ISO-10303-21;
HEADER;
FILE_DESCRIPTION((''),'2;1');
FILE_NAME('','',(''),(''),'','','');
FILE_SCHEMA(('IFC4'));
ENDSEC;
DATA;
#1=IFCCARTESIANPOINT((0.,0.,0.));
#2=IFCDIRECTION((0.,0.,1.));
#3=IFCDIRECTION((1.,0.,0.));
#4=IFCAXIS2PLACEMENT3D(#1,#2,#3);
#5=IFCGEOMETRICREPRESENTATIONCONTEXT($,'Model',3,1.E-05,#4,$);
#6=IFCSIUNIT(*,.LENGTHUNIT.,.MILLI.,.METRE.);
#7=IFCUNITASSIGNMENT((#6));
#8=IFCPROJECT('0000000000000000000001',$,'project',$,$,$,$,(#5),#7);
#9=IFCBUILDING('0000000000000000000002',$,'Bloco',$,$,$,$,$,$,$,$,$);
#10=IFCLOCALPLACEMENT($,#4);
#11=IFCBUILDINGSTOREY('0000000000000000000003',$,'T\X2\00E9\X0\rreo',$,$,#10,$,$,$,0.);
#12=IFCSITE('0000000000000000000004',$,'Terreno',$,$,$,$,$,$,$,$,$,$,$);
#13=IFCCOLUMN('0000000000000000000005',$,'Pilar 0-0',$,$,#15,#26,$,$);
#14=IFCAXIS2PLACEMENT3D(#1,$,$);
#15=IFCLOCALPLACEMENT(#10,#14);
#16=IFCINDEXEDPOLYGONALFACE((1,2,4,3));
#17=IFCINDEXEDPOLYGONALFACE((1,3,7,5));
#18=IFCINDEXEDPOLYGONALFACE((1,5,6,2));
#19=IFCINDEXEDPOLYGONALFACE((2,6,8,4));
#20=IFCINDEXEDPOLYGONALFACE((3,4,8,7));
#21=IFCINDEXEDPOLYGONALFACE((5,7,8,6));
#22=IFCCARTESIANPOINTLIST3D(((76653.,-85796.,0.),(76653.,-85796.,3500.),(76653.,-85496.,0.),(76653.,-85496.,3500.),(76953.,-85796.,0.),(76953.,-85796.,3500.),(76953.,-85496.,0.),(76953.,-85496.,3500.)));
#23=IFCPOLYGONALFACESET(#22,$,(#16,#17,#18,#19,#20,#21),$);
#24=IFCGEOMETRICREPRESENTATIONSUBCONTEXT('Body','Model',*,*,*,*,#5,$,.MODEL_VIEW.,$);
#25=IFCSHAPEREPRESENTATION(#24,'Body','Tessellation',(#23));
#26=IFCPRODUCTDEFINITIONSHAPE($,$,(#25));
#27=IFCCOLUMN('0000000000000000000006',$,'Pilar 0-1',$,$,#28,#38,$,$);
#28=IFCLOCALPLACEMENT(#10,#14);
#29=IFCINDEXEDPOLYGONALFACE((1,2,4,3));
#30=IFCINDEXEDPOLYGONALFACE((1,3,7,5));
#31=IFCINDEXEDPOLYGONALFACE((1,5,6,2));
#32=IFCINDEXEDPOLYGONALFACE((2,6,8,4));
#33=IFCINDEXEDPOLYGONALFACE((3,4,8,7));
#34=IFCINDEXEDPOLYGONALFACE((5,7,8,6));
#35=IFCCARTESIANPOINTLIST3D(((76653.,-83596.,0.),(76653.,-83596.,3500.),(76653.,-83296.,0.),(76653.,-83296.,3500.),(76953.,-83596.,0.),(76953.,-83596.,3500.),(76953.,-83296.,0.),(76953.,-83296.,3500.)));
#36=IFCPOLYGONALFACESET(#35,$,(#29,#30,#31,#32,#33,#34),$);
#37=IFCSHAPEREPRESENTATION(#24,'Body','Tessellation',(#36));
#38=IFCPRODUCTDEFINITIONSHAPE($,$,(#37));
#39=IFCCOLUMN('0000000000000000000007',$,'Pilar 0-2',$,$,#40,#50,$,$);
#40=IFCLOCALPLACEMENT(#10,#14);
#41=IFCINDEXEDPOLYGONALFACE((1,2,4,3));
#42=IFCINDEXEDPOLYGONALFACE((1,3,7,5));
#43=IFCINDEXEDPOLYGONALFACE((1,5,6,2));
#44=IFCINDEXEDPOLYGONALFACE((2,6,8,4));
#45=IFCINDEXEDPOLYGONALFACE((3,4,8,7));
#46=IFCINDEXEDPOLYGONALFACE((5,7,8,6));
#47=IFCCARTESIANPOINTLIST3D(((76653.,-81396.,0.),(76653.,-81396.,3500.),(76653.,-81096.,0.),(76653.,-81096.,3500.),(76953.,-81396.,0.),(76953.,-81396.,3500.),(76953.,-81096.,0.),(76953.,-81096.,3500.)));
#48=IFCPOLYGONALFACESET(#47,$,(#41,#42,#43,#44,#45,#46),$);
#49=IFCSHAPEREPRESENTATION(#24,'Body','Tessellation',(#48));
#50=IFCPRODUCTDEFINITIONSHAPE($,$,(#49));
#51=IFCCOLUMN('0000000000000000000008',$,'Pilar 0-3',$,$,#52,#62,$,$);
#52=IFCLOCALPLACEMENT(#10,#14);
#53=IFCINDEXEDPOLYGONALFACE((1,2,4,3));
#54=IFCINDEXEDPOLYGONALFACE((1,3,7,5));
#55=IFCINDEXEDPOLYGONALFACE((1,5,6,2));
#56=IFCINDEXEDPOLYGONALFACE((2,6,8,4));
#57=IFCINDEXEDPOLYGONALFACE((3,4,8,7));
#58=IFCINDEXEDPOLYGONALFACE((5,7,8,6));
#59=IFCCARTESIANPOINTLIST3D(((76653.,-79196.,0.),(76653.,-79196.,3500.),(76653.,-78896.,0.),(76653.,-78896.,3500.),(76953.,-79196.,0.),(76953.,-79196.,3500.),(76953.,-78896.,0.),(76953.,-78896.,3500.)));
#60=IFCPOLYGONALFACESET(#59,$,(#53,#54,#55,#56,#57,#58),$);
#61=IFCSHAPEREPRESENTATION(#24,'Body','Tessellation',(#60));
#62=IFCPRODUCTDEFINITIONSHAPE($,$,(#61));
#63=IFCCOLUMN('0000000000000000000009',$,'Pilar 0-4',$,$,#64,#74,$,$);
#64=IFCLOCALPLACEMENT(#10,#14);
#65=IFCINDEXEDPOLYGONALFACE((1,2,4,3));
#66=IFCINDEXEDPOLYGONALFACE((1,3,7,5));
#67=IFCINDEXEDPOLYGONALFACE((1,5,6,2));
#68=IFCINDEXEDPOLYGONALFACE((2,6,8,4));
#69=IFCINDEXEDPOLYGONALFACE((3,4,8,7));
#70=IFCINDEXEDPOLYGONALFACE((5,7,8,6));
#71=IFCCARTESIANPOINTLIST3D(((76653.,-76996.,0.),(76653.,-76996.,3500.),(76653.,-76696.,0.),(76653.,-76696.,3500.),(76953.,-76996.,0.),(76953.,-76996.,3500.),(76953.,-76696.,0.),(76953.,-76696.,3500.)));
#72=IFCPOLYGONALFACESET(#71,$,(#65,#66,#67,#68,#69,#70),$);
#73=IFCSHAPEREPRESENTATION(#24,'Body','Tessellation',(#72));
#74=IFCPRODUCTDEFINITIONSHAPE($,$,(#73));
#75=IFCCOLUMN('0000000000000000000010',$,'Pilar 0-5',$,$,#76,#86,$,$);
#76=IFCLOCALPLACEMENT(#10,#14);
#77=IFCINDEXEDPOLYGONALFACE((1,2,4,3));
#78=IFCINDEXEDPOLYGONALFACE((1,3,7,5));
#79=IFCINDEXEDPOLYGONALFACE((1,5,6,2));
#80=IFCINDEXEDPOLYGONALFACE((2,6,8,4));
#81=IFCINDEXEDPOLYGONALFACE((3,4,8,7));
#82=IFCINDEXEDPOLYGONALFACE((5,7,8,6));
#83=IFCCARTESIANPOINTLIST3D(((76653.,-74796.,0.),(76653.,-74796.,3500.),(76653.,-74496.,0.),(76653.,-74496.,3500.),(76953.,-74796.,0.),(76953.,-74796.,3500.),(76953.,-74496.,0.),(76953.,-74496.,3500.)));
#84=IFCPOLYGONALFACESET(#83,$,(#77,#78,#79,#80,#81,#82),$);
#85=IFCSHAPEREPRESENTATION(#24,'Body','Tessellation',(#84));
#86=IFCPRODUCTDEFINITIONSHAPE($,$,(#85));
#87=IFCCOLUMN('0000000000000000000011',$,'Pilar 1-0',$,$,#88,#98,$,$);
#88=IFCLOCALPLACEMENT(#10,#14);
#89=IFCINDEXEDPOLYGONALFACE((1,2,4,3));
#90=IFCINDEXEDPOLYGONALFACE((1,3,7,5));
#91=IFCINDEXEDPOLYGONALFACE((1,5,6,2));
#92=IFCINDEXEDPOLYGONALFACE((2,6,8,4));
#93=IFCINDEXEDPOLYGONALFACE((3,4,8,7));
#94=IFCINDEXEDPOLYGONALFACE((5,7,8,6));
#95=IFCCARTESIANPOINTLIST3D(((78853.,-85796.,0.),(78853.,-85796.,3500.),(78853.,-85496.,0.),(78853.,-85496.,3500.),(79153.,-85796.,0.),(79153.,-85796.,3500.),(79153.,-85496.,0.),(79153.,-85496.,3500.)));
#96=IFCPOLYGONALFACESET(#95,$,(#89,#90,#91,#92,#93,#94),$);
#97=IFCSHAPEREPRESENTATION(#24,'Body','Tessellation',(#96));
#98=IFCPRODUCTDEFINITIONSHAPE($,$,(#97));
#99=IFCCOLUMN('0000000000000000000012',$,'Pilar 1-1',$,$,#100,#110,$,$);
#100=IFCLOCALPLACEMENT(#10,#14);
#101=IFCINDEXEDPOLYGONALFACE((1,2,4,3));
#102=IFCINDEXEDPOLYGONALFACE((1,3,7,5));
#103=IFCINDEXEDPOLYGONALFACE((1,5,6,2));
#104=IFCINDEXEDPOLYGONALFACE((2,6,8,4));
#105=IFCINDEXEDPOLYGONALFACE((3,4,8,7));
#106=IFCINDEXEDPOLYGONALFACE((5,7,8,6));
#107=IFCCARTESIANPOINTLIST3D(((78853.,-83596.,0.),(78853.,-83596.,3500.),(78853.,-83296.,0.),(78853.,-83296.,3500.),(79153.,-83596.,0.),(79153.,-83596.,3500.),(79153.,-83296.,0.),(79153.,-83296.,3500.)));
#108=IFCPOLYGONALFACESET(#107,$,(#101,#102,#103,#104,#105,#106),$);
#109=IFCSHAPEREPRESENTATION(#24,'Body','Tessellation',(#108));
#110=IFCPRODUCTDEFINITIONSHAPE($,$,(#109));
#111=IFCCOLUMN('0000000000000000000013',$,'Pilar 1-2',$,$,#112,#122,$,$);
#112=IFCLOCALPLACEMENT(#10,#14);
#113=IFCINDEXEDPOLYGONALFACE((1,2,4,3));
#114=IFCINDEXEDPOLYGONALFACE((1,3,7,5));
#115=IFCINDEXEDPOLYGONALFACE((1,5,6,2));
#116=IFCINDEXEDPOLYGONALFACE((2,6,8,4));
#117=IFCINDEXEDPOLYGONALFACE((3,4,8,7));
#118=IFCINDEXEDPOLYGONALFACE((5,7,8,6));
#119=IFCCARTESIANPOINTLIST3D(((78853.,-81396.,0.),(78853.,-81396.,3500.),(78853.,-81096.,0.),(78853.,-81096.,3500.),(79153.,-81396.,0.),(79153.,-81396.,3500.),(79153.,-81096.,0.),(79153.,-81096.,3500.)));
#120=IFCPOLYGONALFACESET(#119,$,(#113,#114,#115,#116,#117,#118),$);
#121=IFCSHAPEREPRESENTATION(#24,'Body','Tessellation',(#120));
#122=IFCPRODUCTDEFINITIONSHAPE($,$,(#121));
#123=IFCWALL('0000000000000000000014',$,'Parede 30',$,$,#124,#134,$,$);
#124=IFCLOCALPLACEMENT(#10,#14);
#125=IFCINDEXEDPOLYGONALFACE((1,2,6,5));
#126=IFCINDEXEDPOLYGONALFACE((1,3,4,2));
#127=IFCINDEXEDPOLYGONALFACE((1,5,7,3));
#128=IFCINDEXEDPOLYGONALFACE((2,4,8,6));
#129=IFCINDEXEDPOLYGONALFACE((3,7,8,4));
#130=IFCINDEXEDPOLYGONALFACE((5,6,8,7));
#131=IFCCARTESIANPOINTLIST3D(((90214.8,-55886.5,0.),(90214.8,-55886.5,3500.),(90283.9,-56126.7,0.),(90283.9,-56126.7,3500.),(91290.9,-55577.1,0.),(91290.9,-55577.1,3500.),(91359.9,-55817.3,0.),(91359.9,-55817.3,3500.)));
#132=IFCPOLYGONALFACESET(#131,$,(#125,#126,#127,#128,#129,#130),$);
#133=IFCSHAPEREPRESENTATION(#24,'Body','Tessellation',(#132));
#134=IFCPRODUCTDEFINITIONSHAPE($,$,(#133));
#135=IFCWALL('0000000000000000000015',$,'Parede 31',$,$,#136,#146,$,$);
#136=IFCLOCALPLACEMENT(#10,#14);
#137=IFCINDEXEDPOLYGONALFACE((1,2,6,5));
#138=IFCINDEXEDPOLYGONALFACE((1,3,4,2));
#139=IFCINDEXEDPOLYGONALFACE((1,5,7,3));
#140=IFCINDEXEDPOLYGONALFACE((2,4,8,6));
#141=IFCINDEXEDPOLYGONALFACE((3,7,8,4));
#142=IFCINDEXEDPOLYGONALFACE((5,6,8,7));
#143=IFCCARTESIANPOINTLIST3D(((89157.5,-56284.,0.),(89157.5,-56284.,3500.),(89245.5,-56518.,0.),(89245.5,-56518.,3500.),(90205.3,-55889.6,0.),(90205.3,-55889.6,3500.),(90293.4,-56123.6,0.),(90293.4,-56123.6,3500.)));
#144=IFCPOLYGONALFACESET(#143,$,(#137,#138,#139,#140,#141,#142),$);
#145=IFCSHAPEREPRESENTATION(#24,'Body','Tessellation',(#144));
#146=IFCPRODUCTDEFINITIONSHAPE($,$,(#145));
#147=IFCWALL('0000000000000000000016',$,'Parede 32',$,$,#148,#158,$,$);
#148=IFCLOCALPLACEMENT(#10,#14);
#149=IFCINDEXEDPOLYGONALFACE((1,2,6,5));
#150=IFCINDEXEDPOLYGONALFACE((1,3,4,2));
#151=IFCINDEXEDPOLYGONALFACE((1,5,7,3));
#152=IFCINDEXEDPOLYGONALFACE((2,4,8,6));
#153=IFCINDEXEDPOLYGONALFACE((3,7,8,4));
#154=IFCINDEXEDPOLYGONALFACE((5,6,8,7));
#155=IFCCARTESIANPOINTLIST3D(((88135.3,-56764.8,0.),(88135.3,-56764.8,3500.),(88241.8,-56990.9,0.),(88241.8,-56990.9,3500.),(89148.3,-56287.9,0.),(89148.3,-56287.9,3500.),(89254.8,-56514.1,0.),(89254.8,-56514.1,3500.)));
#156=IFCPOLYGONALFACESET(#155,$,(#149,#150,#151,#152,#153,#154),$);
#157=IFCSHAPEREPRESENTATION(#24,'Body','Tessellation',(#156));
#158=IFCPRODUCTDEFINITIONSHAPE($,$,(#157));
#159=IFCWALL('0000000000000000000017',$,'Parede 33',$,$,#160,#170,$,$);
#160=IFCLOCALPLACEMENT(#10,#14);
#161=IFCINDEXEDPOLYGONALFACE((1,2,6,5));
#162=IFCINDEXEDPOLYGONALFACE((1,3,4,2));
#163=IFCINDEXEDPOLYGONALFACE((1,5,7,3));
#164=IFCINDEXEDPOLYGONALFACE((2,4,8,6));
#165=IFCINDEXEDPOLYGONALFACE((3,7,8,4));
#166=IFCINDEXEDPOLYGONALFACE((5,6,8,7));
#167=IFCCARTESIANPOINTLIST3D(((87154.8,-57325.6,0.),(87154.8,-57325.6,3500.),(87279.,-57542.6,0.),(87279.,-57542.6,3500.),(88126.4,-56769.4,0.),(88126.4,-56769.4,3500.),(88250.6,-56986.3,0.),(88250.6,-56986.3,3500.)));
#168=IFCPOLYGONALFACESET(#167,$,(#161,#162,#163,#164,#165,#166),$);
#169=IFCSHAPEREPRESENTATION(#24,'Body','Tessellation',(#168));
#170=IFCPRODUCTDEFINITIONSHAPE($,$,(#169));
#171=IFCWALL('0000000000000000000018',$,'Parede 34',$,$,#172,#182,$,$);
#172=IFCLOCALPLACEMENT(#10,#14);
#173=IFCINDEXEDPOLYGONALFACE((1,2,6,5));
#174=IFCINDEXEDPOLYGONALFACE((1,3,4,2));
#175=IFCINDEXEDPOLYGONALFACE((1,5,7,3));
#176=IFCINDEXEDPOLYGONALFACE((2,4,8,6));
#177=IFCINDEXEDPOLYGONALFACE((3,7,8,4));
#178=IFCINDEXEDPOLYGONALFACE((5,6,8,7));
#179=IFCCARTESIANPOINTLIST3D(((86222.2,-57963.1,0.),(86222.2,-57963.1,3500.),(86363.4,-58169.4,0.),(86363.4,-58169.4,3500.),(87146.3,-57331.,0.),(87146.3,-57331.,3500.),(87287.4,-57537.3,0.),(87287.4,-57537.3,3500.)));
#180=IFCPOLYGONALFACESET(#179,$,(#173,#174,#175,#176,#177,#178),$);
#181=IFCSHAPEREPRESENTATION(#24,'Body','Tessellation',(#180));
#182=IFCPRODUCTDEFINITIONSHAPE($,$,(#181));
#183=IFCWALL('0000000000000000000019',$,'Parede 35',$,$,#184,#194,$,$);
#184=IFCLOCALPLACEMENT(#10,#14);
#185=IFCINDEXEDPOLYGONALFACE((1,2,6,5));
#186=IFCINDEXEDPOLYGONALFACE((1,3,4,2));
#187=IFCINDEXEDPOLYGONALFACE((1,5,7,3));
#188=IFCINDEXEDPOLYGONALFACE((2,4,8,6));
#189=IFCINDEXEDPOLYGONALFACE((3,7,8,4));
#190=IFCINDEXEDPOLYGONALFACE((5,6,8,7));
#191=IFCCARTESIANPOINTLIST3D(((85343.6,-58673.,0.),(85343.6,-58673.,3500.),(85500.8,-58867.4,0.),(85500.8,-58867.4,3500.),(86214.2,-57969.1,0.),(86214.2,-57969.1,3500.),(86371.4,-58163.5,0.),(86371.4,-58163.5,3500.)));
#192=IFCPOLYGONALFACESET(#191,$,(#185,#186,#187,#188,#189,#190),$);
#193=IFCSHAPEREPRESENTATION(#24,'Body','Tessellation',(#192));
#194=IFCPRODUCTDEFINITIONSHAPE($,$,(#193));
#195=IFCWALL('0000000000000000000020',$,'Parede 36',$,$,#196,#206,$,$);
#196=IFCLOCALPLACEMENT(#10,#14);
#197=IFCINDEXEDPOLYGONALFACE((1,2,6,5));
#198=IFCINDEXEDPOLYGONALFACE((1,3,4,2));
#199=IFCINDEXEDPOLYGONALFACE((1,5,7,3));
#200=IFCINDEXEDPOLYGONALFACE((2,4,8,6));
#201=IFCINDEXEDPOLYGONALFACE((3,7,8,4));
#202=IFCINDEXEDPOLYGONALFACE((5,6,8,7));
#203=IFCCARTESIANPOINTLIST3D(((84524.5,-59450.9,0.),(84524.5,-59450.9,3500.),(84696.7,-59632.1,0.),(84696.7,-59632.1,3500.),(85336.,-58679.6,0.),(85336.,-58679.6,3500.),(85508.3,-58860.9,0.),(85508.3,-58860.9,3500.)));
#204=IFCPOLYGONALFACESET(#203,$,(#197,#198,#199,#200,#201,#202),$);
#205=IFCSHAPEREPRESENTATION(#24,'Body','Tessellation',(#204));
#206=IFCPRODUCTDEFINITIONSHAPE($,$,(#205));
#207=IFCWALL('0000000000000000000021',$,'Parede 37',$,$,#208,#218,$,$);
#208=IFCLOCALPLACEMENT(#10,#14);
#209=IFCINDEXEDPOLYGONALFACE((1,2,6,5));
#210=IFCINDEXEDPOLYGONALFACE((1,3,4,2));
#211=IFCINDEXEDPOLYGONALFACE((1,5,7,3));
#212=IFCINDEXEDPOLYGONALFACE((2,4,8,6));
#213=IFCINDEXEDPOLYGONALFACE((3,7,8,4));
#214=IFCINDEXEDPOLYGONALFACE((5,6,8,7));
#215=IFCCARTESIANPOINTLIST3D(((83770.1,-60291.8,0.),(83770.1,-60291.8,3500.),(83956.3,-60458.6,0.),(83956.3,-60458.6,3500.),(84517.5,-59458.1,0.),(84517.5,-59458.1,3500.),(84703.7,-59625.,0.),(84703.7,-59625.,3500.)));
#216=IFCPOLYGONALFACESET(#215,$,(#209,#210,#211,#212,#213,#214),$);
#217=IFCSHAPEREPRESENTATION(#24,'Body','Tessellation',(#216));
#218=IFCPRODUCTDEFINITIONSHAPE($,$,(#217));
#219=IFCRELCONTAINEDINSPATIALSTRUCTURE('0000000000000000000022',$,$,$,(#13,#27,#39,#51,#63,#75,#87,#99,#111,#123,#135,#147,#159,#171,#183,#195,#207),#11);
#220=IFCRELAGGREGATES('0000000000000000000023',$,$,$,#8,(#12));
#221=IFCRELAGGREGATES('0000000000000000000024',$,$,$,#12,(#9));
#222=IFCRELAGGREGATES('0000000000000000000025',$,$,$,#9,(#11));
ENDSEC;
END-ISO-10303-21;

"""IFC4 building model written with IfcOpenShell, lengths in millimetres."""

from ifc_helpers import new_model, si_unit, origin, origin_with_axes, place, context, subcontext, project, spatial, polyline, outline, extrude, element, save


model = new_model("IFC4")

# Units and contexts
model_context = context("Model", 3, precision=1e-05, world=origin_with_axes())
body_context = subcontext(model_context, "Body", "Model", "MODEL_VIEW")
ifc_project = project(units=[si_unit("LENGTHUNIT", "METRE", prefix="MILLI")], contexts=[model_context])

# Site, building, storey
site = spatial("IfcSite", under=ifc_project, Name="Terreno")
building = spatial("IfcBuilding", under=site, Name="Bloco")
storey_placement = place(None, origin_with_axes())
storey = spatial("IfcBuildingStorey", under=building, at=storey_placement, Name="Térreo", Elevation=0.0)

# Columns
column_1_placement = place(storey_placement, origin_with_axes())
element("IfcColumn", 1, at=column_1_placement, inside=storey, Name="Pilar 0-0", context=body_context, shape_type="SweptSolid", body=[
    extrude(outline(polyline([(76653.0, -85796.0), (76953.0, -85796.0), (76953.0, -85496.0), (76653.0, -85496.0), (76653.0, -85796.0)])), origin(), (0.0, 0.0, 1.0), 3500.0),
])
column_2_placement = place(storey_placement, origin_with_axes())
element("IfcColumn", 2, at=column_2_placement, inside=storey, Name="Pilar 0-1", context=body_context, shape_type="SweptSolid", body=[
    extrude(outline(polyline([(76653.0, -83596.0), (76953.0, -83596.0), (76953.0, -83296.0), (76653.0, -83296.0), (76653.0, -83596.0)])), origin(), (0.0, 0.0, 1.0), 3500.0),
])
column_3_placement = place(storey_placement, origin_with_axes())
element("IfcColumn", 3, at=column_3_placement, inside=storey, Name="Pilar 0-2", context=body_context, shape_type="SweptSolid", body=[
    extrude(outline(polyline([(76653.0, -81396.0), (76953.0, -81396.0), (76953.0, -81096.0), (76653.0, -81096.0), (76653.0, -81396.0)])), origin(), (0.0, 0.0, 1.0), 3500.0),
])
column_4_placement = place(storey_placement, origin_with_axes())
element("IfcColumn", 4, at=column_4_placement, inside=storey, Name="Pilar 0-3", context=body_context, shape_type="SweptSolid", body=[
    extrude(outline(polyline([(76653.0, -79196.0), (76953.0, -79196.0), (76953.0, -78896.0), (76653.0, -78896.0), (76653.0, -79196.0)])), origin(), (0.0, 0.0, 1.0), 3500.0),
])
column_5_placement = place(storey_placement, origin_with_axes())
element("IfcColumn", 5, at=column_5_placement, inside=storey, Name="Pilar 0-4", context=body_context, shape_type="SweptSolid", body=[
    extrude(outline(polyline([(76653.0, -76996.0), (76953.0, -76996.0), (76953.0, -76696.0), (76653.0, -76696.0), (76653.0, -76996.0)])), origin(), (0.0, 0.0, 1.0), 3500.0),
])
column_6_placement = place(storey_placement, origin_with_axes())
element("IfcColumn", 6, at=column_6_placement, inside=storey, Name="Pilar 0-5", context=body_context, shape_type="SweptSolid", body=[
    extrude(outline(polyline([(76653.0, -74796.0), (76953.0, -74796.0), (76953.0, -74496.0), (76653.0, -74496.0), (76653.0, -74796.0)])), origin(), (0.0, 0.0, 1.0), 3500.0),
])
column_7_placement = place(storey_placement, origin_with_axes())
element("IfcColumn", 7, at=column_7_placement, inside=storey, Name="Pilar 1-0", context=body_context, shape_type="SweptSolid", body=[
    extrude(outline(polyline([(78853.0, -85796.0), (79153.0, -85796.0), (79153.0, -85496.0), (78853.0, -85496.0), (78853.0, -85796.0)])), origin(), (0.0, 0.0, 1.0), 3500.0),
])
column_8_placement = place(storey_placement, origin_with_axes())
element("IfcColumn", 8, at=column_8_placement, inside=storey, Name="Pilar 1-1", context=body_context, shape_type="SweptSolid", body=[
    extrude(outline(polyline([(78853.0, -83596.0), (79153.0, -83596.0), (79153.0, -83296.0), (78853.0, -83296.0), (78853.0, -83596.0)])), origin(), (0.0, 0.0, 1.0), 3500.0),
])
column_9_placement = place(storey_placement, origin_with_axes())
element("IfcColumn", 9, at=column_9_placement, inside=storey, Name="Pilar 1-2", context=body_context, shape_type="SweptSolid", body=[
    extrude(outline(polyline([(78853.0, -81396.0), (79153.0, -81396.0), (79153.0, -81096.0), (78853.0, -81096.0), (78853.0, -81396.0)])), origin(), (0.0, 0.0, 1.0), 3500.0),
])

# Walls
wall_1_placement = place(storey_placement, origin_with_axes())
element("IfcWall", 10, at=wall_1_placement, inside=storey, Name="Parede 30", context=body_context, shape_type="SweptSolid", body=[
    extrude(outline(polyline([(91359.9, -55817.3), (90283.9, -56126.7), (90214.8, -55886.5), (91290.9, -55577.1), (91359.9, -55817.3)])), origin(), (0.0, 0.0, 1.0), 3500.0),
])
wall_2_placement = place(storey_placement, origin_with_axes())
element("IfcWall", 11, at=wall_2_placement, inside=storey, Name="Parede 31", context=body_context, shape_type="SweptSolid", body=[
    extrude(outline(polyline([(90293.4, -56123.6), (89245.5, -56518.0), (89157.5, -56284.0), (90205.3, -55889.6), (90293.4, -56123.6)])), origin(), (0.0, 0.0, 1.0), 3500.0),
])
wall_3_placement = place(storey_placement, origin_with_axes())
element("IfcWall", 12, at=wall_3_placement, inside=storey, Name="Parede 32", context=body_context, shape_type="SweptSolid", body=[
    extrude(outline(polyline([(89254.8, -56514.1), (88241.8, -56990.9), (88135.3, -56764.8), (89148.3, -56287.9), (89254.8, -56514.1)])), origin(), (0.0, 0.0, 1.0), 3500.0),
])
wall_4_placement = place(storey_placement, origin_with_axes())
element("IfcWall", 13, at=wall_4_placement, inside=storey, Name="Parede 33", context=body_context, shape_type="SweptSolid", body=[
    extrude(outline(polyline([(88250.6, -56986.3), (87279.0, -57542.6), (87154.8, -57325.6), (88126.4, -56769.4), (88250.6, -56986.3)])), origin(), (0.0, 0.0, 1.0), 3500.0),
])
wall_5_placement = place(storey_placement, origin_with_axes())
element("IfcWall", 14, at=wall_5_placement, inside=storey, Name="Parede 34", context=body_context, shape_type="SweptSolid", body=[
    extrude(outline(polyline([(87287.4, -57537.3), (86363.4, -58169.4), (86222.2, -57963.1), (87146.3, -57331.0), (87287.4, -57537.3)])), origin(), (0.0, 0.0, 1.0), 3500.0),
])
wall_6_placement = place(storey_placement, origin_with_axes())
element("IfcWall", 15, at=wall_6_placement, inside=storey, Name="Parede 35", context=body_context, shape_type="SweptSolid", body=[
    extrude(outline(polyline([(86371.4, -58163.5), (85500.8, -58867.4), (85343.6, -58673.0), (86214.2, -57969.1), (86371.4, -58163.5)])), origin(), (0.0, 0.0, 1.0), 3500.0),
])
wall_7_placement = place(storey_placement, origin_with_axes())
element("IfcWall", 16, at=wall_7_placement, inside=storey, Name="Parede 36", context=body_context, shape_type="SweptSolid", body=[
    extrude(outline(polyline([(85508.3, -58860.9), (84696.7, -59632.1), (84524.5, -59450.9), (85336.0, -58679.6), (85508.3, -58860.9)])), origin(), (0.0, 0.0, 1.0), 3500.0),
])
wall_8_placement = place(storey_placement, origin_with_axes())
element("IfcWall", 17, at=wall_8_placement, inside=storey, Name="Parede 37", context=body_context, shape_type="SweptSolid", body=[
    extrude(outline(polyline([(84703.7, -59625.0), (83956.3, -60458.6), (83770.1, -60291.8), (84517.5, -59458.1), (84703.7, -59625.0)])), origin(), (0.0, 0.0, 1.0), 3500.0),
])

save(model, "model.ifc")
